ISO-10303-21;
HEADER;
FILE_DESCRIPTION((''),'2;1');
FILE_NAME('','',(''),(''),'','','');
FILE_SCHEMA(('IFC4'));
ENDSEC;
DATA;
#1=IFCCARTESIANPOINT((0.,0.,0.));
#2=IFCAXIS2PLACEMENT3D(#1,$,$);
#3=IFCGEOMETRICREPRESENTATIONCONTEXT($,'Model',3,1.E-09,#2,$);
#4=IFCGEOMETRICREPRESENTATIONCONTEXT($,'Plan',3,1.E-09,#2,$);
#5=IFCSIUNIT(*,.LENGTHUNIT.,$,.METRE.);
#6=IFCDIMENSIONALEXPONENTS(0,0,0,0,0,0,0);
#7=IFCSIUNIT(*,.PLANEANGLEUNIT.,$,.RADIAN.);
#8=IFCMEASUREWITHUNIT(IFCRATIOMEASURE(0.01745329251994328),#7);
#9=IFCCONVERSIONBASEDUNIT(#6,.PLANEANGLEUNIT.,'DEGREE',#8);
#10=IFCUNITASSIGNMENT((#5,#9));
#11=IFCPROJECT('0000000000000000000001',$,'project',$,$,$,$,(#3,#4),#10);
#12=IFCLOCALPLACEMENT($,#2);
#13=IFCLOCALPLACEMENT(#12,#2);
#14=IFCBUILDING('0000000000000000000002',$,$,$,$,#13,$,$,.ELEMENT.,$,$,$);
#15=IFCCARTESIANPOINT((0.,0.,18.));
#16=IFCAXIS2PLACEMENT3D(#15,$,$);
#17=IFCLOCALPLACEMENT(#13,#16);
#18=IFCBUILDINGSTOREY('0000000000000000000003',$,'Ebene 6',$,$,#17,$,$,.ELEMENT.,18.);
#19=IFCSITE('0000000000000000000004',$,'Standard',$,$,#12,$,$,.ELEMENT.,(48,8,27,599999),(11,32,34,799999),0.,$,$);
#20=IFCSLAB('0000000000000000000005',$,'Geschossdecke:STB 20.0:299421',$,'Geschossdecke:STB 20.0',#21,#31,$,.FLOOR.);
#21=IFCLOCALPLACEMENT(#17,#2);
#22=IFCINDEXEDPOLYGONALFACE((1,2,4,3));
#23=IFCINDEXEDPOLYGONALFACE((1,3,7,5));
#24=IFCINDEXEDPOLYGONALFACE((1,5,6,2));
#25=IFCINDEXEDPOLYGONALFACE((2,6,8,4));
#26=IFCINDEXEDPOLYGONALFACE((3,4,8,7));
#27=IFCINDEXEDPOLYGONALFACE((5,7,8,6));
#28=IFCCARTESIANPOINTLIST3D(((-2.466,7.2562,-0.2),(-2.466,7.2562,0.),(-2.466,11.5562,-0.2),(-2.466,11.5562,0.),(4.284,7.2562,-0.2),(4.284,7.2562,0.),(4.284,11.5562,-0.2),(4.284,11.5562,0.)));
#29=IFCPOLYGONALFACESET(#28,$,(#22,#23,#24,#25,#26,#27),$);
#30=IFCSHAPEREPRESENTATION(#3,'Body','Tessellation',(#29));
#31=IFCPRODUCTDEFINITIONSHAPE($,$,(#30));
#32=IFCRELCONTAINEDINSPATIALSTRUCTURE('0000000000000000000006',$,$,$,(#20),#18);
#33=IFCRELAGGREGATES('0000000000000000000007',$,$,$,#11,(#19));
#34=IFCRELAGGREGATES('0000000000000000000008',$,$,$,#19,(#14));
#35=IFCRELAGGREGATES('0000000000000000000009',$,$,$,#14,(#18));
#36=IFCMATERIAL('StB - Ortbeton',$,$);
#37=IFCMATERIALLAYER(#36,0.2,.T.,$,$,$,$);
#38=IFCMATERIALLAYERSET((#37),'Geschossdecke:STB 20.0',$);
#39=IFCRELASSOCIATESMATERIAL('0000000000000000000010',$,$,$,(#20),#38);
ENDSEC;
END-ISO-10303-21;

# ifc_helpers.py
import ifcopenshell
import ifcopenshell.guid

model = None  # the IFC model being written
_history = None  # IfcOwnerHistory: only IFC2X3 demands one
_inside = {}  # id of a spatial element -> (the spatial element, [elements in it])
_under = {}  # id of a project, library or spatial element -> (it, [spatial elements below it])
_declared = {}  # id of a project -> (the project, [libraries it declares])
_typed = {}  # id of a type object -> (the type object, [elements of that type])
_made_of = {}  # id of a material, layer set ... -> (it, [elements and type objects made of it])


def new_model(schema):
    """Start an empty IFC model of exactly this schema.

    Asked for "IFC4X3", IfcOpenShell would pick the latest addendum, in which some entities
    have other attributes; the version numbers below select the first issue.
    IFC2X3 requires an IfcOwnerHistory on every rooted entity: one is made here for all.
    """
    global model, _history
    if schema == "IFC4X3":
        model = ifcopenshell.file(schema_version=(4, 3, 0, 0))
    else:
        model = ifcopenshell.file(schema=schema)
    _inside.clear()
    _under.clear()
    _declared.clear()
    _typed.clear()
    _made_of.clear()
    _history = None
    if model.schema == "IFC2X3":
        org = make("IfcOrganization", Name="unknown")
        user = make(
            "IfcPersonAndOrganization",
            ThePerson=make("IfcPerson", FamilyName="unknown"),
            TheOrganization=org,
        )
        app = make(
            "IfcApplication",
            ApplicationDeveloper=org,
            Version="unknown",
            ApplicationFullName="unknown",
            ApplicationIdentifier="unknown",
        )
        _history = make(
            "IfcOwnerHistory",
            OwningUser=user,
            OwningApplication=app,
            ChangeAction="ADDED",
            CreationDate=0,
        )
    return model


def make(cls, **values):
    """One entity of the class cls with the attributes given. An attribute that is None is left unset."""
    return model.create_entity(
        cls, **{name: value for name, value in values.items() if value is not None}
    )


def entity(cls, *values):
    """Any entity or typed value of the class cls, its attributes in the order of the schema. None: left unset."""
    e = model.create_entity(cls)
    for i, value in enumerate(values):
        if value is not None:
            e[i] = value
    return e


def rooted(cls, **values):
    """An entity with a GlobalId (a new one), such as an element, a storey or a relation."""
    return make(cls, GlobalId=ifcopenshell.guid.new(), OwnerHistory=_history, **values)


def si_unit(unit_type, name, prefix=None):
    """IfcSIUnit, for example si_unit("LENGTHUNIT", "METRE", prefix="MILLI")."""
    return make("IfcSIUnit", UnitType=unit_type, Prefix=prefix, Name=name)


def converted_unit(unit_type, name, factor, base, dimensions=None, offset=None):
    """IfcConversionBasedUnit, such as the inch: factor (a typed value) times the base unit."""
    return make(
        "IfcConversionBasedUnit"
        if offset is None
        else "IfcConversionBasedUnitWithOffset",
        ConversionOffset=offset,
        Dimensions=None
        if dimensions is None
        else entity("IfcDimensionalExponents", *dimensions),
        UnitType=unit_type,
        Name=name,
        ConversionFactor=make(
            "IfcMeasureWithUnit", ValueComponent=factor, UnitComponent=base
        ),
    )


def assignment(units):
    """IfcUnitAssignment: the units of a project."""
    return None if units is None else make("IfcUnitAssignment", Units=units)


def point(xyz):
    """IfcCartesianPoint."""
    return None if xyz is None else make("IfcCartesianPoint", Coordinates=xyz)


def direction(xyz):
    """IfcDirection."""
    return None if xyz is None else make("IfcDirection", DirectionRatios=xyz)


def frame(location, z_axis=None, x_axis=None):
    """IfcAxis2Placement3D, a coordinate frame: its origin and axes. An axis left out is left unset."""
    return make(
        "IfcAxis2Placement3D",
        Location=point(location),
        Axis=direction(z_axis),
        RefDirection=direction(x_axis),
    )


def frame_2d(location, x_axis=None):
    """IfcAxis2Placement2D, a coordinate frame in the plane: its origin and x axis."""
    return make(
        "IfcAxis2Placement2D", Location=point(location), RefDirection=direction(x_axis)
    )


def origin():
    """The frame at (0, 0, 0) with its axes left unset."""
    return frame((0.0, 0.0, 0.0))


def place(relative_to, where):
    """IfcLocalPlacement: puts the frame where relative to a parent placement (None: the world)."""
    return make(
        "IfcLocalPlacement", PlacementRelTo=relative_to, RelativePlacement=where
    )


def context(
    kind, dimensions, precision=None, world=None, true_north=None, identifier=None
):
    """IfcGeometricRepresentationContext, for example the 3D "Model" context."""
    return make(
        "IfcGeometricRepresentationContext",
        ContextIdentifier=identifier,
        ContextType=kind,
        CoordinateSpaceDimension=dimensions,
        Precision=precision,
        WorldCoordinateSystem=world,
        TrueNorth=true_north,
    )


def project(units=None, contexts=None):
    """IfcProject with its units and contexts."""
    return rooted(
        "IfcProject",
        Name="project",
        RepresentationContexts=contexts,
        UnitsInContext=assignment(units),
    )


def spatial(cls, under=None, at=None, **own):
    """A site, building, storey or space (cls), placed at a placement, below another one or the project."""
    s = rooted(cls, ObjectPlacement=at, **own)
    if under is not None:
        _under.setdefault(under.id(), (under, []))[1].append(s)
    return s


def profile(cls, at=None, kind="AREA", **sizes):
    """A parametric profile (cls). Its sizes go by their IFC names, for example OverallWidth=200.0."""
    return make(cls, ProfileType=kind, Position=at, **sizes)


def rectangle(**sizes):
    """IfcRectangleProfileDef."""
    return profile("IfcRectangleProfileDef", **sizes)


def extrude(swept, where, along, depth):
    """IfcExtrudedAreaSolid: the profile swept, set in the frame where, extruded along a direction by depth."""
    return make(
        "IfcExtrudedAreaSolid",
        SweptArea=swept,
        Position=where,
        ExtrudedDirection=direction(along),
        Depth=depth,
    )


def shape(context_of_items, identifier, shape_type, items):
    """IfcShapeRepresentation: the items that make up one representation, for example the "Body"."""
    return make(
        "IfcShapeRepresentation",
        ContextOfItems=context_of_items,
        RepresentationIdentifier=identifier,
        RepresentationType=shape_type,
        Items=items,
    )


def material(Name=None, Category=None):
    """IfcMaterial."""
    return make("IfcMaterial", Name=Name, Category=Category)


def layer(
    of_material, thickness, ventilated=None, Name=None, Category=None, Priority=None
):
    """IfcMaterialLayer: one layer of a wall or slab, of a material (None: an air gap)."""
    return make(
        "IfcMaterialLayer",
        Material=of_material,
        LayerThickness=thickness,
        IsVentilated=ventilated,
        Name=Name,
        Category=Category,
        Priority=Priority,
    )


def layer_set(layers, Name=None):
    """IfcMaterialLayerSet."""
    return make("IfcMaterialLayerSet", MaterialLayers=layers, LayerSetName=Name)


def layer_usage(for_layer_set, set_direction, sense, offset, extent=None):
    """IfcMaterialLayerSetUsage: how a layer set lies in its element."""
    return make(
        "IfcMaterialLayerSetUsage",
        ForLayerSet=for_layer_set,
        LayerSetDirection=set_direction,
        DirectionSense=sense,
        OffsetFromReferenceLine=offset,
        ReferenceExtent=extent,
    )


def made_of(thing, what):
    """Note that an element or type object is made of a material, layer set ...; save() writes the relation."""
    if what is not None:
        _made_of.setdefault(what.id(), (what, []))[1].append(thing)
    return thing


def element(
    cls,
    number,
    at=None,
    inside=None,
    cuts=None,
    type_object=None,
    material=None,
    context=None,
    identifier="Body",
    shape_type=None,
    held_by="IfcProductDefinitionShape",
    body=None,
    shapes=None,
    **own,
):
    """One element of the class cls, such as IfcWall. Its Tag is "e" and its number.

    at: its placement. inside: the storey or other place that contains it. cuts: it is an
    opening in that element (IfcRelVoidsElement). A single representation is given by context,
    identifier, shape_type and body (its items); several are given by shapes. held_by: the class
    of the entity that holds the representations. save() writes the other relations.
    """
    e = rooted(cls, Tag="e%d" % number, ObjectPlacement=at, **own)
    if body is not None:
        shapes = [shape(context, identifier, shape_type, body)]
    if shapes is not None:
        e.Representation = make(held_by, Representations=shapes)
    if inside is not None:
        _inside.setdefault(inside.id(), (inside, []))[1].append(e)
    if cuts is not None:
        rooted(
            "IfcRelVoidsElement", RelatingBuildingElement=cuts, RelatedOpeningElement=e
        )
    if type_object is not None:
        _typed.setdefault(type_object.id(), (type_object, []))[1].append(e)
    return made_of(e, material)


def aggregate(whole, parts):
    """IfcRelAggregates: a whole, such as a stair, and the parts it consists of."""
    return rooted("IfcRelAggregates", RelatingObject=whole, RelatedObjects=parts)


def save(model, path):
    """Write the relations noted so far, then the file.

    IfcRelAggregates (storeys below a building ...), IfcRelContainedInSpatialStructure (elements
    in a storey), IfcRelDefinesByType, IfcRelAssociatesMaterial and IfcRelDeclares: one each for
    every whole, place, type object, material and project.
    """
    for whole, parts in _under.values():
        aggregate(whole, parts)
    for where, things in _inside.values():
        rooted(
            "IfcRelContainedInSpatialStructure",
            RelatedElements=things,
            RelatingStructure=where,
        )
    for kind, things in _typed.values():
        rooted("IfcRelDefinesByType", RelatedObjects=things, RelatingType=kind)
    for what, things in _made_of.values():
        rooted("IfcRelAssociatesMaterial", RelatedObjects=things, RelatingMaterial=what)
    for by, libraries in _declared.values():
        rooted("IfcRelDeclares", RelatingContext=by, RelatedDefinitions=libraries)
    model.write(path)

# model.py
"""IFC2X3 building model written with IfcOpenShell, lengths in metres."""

from ifc_helpers import new_model, entity, si_unit, converted_unit, frame, frame_2d, origin, place, context, project, spatial, rectangle, extrude, material, layer, layer_set, layer_usage, element, save


model = new_model("IFC2X3")

# Units and contexts
model_context = context("Model", 3, precision=1e-09, world=origin())
plan_context = context("Plan", 3, precision=1e-09, world=origin())
ifc_project = project(units=[si_unit("LENGTHUNIT", "METRE"), converted_unit("PLANEANGLEUNIT", "DEGREE", entity("IfcRatioMeasure", 0.01745329251994328), si_unit("PLANEANGLEUNIT", "RADIAN"), dimensions=[0, 0, 0, 0, 0, 0, 0])], contexts=[model_context, plan_context])

# Site, building, storey
site_placement = place(None, origin())
site = spatial("IfcSite", under=ifc_project, at=site_placement, Name="Standard", CompositionType="ELEMENT", RefLatitude=(48, 8, 27, 599999), RefLongitude=(11, 32, 34, 799999), RefElevation=0.0)
building_placement = place(site_placement, origin())
building = spatial("IfcBuilding", under=site, at=building_placement, CompositionType="ELEMENT")
storey_placement = place(building_placement, frame((0.0, 0.0, 18.0)))
storey = spatial("IfcBuildingStorey", under=building, at=storey_placement, Name="Ebene 6", CompositionType="ELEMENT", Elevation=18.0)

# Slab
ifc_material = material(Name="StB - Ortbeton")
ifc_layer = layer(ifc_material, 0.2, ventilated=True)
ifc_layer_set = layer_set([ifc_layer], Name="Geschossdecke:STB 20.0")
ifc_layer_usage = layer_usage(ifc_layer_set, "AXIS3", "POSITIVE", 0.0)
slab_placement = place(storey_placement, frame((-2.466, 7.2562, -0.2)))
element("IfcSlab", 1, at=slab_placement, inside=storey, material=ifc_layer_usage, Name="Geschossdecke:STB 20.0:299421", ObjectType="Geschossdecke:STB 20.0", PredefinedType="FLOOR", context=model_context, shape_type="SweptSolid", body=[
    extrude(rectangle(XDim=4.3, YDim=6.75, at=frame_2d((0.0, 0.0), x_axis=(0.0, -1.0))), frame((3.375, 2.15, 0.2), z_axis=(0.0, 0.0, -1.0), x_axis=(-1.0, 0.0, 0.0)), (0.0, 0.0, 1.0), 0.2),
])

save(model, "model.ifc")
